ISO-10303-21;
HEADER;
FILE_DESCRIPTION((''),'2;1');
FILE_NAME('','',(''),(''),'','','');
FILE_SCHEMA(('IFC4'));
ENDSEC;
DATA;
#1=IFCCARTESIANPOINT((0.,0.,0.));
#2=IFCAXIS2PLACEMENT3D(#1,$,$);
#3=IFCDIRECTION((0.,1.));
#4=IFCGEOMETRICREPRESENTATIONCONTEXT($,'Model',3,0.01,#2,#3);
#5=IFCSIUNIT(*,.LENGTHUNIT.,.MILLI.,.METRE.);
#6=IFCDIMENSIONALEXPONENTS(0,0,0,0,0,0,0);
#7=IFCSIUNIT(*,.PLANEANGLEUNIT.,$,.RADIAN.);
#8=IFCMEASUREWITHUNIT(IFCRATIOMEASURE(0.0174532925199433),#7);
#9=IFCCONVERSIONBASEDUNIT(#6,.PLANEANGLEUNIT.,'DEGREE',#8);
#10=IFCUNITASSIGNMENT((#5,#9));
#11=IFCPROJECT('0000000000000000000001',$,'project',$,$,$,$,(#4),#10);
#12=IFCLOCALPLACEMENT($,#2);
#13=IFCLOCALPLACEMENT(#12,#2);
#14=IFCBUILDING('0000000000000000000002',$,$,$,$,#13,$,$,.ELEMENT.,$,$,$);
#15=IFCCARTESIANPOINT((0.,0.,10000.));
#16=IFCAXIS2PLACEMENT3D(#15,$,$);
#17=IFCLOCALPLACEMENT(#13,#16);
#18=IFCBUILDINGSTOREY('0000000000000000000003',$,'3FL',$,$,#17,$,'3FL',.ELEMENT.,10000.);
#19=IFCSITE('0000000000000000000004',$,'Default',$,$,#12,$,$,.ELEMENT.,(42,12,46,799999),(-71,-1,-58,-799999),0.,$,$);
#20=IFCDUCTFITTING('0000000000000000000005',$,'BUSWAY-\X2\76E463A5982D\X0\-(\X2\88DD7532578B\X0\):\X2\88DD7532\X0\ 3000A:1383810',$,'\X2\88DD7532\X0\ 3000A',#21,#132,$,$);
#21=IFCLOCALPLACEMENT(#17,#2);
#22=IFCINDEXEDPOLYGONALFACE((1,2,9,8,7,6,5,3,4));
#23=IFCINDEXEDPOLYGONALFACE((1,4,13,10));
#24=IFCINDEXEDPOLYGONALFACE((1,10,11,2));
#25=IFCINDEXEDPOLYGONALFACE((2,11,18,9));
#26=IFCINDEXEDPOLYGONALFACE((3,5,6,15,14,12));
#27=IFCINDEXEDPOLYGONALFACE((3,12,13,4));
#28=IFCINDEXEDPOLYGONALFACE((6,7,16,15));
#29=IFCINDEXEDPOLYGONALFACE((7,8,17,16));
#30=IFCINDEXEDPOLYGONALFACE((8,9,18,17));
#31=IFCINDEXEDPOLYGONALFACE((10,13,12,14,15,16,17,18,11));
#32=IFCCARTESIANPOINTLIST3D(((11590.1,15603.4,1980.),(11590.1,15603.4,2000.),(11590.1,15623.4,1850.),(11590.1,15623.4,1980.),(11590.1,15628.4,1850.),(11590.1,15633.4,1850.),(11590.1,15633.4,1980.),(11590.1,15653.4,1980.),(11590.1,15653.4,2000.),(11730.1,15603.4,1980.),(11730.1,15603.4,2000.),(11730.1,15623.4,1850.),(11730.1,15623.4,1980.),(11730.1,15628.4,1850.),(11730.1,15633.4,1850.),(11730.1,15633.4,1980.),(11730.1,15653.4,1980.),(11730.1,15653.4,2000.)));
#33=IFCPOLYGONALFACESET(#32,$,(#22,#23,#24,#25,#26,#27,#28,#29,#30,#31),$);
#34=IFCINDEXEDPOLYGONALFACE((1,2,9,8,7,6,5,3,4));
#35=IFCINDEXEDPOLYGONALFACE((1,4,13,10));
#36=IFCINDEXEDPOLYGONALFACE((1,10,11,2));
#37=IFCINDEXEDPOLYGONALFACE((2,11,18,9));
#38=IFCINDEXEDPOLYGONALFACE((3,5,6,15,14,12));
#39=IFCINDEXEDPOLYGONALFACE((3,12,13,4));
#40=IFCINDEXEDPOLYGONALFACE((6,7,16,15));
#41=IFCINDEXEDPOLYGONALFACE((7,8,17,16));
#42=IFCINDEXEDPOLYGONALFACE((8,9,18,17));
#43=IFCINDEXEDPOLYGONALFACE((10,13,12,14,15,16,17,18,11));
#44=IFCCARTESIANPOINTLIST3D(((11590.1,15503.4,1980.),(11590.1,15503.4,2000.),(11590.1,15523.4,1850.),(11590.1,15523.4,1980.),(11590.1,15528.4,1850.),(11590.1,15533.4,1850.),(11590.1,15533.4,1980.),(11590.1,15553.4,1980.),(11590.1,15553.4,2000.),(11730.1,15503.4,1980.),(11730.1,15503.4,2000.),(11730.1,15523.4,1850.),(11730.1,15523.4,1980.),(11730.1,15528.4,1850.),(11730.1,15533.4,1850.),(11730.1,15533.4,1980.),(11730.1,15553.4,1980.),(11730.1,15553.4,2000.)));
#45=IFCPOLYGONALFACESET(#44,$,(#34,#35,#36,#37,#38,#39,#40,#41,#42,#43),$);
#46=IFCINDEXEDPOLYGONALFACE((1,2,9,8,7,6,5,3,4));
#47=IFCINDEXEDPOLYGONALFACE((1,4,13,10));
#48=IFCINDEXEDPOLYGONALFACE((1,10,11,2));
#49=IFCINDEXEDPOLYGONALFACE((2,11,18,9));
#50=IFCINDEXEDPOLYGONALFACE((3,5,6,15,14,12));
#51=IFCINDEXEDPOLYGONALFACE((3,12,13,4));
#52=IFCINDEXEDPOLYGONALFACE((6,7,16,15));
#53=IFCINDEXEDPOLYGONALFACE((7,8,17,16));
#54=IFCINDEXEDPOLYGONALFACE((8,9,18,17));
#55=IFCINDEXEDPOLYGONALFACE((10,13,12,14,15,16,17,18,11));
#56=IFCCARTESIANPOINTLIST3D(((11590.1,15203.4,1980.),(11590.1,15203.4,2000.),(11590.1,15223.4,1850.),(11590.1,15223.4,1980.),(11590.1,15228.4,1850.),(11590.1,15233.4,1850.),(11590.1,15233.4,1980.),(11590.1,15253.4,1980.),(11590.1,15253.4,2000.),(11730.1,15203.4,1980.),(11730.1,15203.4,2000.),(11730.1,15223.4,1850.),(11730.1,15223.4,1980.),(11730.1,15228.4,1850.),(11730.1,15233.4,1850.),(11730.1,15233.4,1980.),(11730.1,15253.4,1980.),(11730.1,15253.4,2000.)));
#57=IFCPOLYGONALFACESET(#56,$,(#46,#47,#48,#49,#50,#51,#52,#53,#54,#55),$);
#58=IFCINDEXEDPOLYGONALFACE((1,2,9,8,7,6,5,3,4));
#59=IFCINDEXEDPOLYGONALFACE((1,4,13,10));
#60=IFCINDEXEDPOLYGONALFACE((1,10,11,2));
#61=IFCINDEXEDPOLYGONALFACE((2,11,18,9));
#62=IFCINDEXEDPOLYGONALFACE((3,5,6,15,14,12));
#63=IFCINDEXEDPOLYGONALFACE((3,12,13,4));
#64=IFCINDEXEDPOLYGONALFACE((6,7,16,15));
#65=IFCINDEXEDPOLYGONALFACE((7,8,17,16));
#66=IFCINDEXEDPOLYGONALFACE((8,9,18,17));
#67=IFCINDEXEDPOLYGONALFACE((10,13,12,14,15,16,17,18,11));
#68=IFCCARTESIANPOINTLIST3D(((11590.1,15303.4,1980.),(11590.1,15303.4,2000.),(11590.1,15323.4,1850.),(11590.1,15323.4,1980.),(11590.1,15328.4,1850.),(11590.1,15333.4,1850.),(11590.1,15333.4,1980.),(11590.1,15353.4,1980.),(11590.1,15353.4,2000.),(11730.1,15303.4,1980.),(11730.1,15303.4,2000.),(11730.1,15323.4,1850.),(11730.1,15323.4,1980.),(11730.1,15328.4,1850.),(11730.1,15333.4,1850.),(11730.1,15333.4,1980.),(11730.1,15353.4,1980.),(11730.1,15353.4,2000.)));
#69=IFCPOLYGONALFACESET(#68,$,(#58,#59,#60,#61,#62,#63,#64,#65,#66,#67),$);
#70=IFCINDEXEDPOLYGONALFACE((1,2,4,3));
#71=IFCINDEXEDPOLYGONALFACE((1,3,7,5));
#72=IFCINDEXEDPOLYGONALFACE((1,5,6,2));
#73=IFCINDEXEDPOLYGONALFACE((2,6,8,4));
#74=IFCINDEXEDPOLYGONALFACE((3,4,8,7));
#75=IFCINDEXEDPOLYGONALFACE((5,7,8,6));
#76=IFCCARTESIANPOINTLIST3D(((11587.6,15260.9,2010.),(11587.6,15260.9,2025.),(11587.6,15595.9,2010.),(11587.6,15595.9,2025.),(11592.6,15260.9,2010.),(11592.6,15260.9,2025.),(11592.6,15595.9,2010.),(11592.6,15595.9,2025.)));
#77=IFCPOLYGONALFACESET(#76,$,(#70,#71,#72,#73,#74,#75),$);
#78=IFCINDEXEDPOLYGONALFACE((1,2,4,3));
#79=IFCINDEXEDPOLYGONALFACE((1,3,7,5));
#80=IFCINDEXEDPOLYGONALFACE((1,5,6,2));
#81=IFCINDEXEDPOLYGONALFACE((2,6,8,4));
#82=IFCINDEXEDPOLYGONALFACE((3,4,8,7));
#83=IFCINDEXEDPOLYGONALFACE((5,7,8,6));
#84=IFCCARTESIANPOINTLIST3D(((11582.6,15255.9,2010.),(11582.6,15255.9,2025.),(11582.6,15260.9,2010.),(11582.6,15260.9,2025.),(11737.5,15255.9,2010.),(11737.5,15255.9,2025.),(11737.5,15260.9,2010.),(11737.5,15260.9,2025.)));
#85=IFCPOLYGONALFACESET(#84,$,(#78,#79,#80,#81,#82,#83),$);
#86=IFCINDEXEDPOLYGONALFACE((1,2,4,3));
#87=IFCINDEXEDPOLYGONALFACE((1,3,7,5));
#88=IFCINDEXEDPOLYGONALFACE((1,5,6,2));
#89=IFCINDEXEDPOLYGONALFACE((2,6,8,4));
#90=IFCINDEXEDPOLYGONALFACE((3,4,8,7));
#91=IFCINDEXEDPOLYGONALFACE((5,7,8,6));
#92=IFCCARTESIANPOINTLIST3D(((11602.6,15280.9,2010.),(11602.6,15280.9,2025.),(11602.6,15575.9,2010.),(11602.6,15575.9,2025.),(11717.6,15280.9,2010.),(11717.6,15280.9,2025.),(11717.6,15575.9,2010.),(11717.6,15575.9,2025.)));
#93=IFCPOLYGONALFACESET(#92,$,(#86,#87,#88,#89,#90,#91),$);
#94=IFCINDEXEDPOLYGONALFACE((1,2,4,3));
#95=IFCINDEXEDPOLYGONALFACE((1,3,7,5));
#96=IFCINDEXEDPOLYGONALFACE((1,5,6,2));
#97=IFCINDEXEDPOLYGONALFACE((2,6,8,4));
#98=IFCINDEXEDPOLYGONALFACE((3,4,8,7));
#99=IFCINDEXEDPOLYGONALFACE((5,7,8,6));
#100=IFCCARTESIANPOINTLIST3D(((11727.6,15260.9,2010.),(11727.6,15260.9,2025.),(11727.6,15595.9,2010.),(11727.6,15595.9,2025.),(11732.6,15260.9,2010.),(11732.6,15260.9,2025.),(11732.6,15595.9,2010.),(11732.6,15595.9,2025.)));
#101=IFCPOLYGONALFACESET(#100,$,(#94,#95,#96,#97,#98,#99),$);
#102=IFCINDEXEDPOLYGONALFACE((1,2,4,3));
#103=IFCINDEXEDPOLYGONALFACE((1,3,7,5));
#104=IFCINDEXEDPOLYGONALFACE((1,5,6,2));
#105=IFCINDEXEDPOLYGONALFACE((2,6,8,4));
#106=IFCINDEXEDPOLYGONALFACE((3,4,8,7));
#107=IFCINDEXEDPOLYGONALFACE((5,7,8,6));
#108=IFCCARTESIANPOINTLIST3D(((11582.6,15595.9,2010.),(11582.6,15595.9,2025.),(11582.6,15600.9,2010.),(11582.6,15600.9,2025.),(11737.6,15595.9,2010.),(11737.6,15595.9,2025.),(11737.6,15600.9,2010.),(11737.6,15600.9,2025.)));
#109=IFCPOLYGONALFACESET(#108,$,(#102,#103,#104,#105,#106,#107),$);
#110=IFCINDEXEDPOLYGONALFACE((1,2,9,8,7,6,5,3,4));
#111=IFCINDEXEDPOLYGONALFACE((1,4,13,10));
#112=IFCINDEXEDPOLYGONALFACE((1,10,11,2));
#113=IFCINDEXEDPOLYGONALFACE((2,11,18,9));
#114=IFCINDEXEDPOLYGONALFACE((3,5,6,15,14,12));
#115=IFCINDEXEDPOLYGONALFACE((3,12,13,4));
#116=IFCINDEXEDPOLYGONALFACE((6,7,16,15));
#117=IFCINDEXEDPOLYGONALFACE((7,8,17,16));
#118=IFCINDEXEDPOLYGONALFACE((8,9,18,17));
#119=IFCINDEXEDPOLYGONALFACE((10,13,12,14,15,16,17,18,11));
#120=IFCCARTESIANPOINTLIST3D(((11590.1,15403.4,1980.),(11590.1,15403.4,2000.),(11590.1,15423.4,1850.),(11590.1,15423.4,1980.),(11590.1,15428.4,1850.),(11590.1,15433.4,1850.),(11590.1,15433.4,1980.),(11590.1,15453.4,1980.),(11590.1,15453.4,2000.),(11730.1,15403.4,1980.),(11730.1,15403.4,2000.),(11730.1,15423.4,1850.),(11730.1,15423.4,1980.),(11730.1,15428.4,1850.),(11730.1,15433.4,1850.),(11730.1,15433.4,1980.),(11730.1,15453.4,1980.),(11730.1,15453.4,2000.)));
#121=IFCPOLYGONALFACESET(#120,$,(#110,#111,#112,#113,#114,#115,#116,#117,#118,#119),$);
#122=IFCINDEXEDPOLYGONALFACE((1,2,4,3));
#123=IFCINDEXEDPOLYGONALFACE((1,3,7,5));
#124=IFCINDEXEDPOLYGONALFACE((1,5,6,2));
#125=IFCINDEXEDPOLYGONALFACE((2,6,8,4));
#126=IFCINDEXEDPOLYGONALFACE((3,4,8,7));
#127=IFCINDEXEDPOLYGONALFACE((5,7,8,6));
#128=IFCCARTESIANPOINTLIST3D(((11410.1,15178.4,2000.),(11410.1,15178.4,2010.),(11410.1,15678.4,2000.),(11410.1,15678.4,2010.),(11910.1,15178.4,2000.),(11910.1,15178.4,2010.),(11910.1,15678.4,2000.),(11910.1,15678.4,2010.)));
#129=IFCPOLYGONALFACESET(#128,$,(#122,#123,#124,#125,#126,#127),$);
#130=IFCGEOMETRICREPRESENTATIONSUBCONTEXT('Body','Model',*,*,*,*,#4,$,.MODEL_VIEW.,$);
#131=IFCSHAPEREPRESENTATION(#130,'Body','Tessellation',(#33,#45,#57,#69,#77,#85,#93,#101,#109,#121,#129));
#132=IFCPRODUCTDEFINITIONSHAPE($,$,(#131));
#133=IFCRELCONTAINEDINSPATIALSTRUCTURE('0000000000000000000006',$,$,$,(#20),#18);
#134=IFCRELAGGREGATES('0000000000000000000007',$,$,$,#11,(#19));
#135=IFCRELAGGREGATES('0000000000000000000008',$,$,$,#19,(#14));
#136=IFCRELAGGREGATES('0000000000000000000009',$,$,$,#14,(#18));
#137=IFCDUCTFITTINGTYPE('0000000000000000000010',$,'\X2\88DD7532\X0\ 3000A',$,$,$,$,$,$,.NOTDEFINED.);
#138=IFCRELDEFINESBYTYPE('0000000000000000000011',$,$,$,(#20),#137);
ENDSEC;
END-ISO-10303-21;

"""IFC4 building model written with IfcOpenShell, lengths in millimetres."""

from ifc_helpers import new_model, entity, si_unit, converted_unit, direction, frame, frame_2d, origin, origin_2d_with_axis, place, context, subcontext, project, spatial, polyline, rectangle, outline, extrude, source, transform, mapped, type_object, type_shapes, element, save


model = new_model("IFC4")

# Units and contexts
model_context = context("Model", 3, precision=0.01, world=origin(), true_north=direction((0.0, 1.0)))
body_context = subcontext(model_context, "Body", "Model", "MODEL_VIEW")
ifc_project = project(units=[si_unit("LENGTHUNIT", "METRE", prefix="MILLI"), converted_unit("PLANEANGLEUNIT", "DEGREE", entity("IfcRatioMeasure", 0.0174532925199433), si_unit("PLANEANGLEUNIT", "RADIAN"), dimensions=[0, 0, 0, 0, 0, 0, 0])], contexts=[model_context])

# Site, building, storey
site_placement = place(None, origin())
site = spatial("IfcSite", under=ifc_project, at=site_placement, Name="Default", CompositionType="ELEMENT", RefLatitude=(42, 12, 46, 799999), RefLongitude=(-71, -1, -58, -799999), RefElevation=0.0)
building_placement = place(site_placement, origin())
building = spatial("IfcBuilding", under=site, at=building_placement, CompositionType="ELEMENT")
storey_placement = place(building_placement, frame((0.0, 0.0, 10000.0)))
storey = spatial("IfcBuildingStorey", under=building, at=storey_placement, Name="3FL", LongName="3FL", CompositionType="ELEMENT", Elevation=10000.0)

# Duct fitting
duct_fitting_type_1 = type_object("IfcDuctFittingType", Name="裝甲 3000A", PredefinedType="NOTDEFINED")
shared_shape_1 = source(origin(), body_context, "Body", "SweptSolid", [
    extrude(outline(polyline([(-25.0, -58.9), (25.0, -58.9), (25.0, -38.9), (5.0, -38.9), (5.0, 91.1), (0.0, 91.1), (-5.0, 91.1), (-5.0, -38.9), (-25.0, -38.9), (-25.0, -58.9)])), frame((-200.0, -70.0, -58.9), z_axis=(0.0, 1.0, 0.0), x_axis=(1.0, 0.0, 0.0)), (0.0, 0.0, 1.0), 140.0),
    extrude(outline(polyline([(-25.0, -58.9), (25.0, -58.9), (25.0, -38.9), (5.0, -38.9), (5.0, 91.1), (0.0, 91.1), (-5.0, 91.1), (-5.0, -38.9), (-25.0, -38.9), (-25.0, -58.9)])), frame((-100.0, -70.0, -58.9), z_axis=(0.0, 1.0, 0.0), x_axis=(1.0, 0.0, 0.0)), (0.0, 0.0, 1.0), 140.0),
    extrude(outline(polyline([(-58.9, -25.0), (-38.9, -25.0), (-38.9, -5.0), (91.1, -5.0), (91.1, 0.0), (91.1, 5.0), (-38.9, 5.0), (-38.9, 25.0), (-58.9, 25.0), (-58.9, -25.0)])), frame((200.0, -70.0, -58.9), z_axis=(0.0, 1.0, 0.0), x_axis=(0.0, 0.0, -1.0)), (0.0, 0.0, 1.0), 140.0),
    extrude(outline(polyline([(-58.9, -25.0), (-38.9, -25.0), (-38.9, -5.0), (91.1, -5.0), (91.1, 0.0), (91.1, 5.0), (-38.9, 5.0), (-38.9, 25.0), (-58.9, 25.0), (-58.9, -25.0)])), frame((100.0, -70.0, -58.9), z_axis=(0.0, 1.0, 0.0), x_axis=(0.0, 0.0, -1.0)), (0.0, 0.0, 1.0), 140.0),
    extrude(rectangle(XDim=335.0, YDim=5.0, at=origin_2d_with_axis()), frame((0.0, -70.0, 10.0), z_axis=(0.0, 0.0, 1.0), x_axis=(-1.0, 0.0, 0.0)), (0.0, 0.0, 1.0), 15.0),
    extrude(rectangle(XDim=5.0, YDim=154.9, at=frame_2d((0.0, 0.0), x_axis=(1.0, 0.0))), frame((170.0, -0.1, 10.0), z_axis=(0.0, 0.0, 1.0), x_axis=(-1.0, 0.0, 0.0)), (0.0, 0.0, 1.0), 15.0),
    extrude(rectangle(XDim=295.0, YDim=115.0, at=origin_2d_with_axis()), frame((0.0, 0.0, 10.0), z_axis=(0.0, 0.0, 1.0), x_axis=(-1.0, 0.0, 0.0)), (0.0, 0.0, 1.0), 15.0),
    extrude(rectangle(XDim=335.0, YDim=5.0, at=origin_2d_with_axis()), frame((0.0, 70.0, 10.0), z_axis=(0.0, 0.0, 1.0), x_axis=(-1.0, 0.0, 0.0)), (0.0, 0.0, 1.0), 15.0),
    extrude(rectangle(XDim=5.0, YDim=155.0, at=origin_2d_with_axis()), frame((-170.0, 0.0, 10.0), z_axis=(0.0, 0.0, 1.0), x_axis=(-1.0, 0.0, 0.0)), (0.0, 0.0, 1.0), 15.0),
    extrude(outline(polyline([(-58.9, -25.0), (-38.9, -25.0), (-38.9, -5.0), (91.1, -5.0), (91.1, 0.0), (91.1, 5.0), (-38.9, 5.0), (-38.9, 25.0), (-58.9, 25.0), (-58.9, -25.0)])), frame((0.0, -70.0, -58.9), z_axis=(0.0, 1.0, 0.0), x_axis=(0.0, 0.0, -1.0)), (0.0, 0.0, 1.0), 140.0),
    extrude(rectangle(XDim=500.0, YDim=500.0, at=origin_2d_with_axis()), frame((0.0, 0.0, 0.0), z_axis=(0.0, 0.0, 1.0), x_axis=(0.0, 1.0, 0.0)), (0.0, 0.0, 1.0), 10.0),
])
type_shapes(duct_fitting_type_1, [shared_shape_1])
for number, where, z_axis, x_axis, name in (
    (1, (11660.1, 15428.4, 2000.0), (0.0, 0.0, 1.0), (0.0, -1.0, 0.0), "BUSWAY-盤接頭-(裝甲型):裝甲 3000A:1383810"),
):
    element("IfcDuctFitting", number, at=place(storey_placement, frame(where, z_axis=z_axis, x_axis=x_axis)), inside=storey, type_object=duct_fitting_type_1, Name=name, ObjectType="裝甲 3000A", context=body_context, shape_type="MappedRepresentation", body=[
        mapped(shared_shape_1, transform((0.0, 0.0, 0.0), scale=1.0)),
    ])

save(model, "model.ifc")
